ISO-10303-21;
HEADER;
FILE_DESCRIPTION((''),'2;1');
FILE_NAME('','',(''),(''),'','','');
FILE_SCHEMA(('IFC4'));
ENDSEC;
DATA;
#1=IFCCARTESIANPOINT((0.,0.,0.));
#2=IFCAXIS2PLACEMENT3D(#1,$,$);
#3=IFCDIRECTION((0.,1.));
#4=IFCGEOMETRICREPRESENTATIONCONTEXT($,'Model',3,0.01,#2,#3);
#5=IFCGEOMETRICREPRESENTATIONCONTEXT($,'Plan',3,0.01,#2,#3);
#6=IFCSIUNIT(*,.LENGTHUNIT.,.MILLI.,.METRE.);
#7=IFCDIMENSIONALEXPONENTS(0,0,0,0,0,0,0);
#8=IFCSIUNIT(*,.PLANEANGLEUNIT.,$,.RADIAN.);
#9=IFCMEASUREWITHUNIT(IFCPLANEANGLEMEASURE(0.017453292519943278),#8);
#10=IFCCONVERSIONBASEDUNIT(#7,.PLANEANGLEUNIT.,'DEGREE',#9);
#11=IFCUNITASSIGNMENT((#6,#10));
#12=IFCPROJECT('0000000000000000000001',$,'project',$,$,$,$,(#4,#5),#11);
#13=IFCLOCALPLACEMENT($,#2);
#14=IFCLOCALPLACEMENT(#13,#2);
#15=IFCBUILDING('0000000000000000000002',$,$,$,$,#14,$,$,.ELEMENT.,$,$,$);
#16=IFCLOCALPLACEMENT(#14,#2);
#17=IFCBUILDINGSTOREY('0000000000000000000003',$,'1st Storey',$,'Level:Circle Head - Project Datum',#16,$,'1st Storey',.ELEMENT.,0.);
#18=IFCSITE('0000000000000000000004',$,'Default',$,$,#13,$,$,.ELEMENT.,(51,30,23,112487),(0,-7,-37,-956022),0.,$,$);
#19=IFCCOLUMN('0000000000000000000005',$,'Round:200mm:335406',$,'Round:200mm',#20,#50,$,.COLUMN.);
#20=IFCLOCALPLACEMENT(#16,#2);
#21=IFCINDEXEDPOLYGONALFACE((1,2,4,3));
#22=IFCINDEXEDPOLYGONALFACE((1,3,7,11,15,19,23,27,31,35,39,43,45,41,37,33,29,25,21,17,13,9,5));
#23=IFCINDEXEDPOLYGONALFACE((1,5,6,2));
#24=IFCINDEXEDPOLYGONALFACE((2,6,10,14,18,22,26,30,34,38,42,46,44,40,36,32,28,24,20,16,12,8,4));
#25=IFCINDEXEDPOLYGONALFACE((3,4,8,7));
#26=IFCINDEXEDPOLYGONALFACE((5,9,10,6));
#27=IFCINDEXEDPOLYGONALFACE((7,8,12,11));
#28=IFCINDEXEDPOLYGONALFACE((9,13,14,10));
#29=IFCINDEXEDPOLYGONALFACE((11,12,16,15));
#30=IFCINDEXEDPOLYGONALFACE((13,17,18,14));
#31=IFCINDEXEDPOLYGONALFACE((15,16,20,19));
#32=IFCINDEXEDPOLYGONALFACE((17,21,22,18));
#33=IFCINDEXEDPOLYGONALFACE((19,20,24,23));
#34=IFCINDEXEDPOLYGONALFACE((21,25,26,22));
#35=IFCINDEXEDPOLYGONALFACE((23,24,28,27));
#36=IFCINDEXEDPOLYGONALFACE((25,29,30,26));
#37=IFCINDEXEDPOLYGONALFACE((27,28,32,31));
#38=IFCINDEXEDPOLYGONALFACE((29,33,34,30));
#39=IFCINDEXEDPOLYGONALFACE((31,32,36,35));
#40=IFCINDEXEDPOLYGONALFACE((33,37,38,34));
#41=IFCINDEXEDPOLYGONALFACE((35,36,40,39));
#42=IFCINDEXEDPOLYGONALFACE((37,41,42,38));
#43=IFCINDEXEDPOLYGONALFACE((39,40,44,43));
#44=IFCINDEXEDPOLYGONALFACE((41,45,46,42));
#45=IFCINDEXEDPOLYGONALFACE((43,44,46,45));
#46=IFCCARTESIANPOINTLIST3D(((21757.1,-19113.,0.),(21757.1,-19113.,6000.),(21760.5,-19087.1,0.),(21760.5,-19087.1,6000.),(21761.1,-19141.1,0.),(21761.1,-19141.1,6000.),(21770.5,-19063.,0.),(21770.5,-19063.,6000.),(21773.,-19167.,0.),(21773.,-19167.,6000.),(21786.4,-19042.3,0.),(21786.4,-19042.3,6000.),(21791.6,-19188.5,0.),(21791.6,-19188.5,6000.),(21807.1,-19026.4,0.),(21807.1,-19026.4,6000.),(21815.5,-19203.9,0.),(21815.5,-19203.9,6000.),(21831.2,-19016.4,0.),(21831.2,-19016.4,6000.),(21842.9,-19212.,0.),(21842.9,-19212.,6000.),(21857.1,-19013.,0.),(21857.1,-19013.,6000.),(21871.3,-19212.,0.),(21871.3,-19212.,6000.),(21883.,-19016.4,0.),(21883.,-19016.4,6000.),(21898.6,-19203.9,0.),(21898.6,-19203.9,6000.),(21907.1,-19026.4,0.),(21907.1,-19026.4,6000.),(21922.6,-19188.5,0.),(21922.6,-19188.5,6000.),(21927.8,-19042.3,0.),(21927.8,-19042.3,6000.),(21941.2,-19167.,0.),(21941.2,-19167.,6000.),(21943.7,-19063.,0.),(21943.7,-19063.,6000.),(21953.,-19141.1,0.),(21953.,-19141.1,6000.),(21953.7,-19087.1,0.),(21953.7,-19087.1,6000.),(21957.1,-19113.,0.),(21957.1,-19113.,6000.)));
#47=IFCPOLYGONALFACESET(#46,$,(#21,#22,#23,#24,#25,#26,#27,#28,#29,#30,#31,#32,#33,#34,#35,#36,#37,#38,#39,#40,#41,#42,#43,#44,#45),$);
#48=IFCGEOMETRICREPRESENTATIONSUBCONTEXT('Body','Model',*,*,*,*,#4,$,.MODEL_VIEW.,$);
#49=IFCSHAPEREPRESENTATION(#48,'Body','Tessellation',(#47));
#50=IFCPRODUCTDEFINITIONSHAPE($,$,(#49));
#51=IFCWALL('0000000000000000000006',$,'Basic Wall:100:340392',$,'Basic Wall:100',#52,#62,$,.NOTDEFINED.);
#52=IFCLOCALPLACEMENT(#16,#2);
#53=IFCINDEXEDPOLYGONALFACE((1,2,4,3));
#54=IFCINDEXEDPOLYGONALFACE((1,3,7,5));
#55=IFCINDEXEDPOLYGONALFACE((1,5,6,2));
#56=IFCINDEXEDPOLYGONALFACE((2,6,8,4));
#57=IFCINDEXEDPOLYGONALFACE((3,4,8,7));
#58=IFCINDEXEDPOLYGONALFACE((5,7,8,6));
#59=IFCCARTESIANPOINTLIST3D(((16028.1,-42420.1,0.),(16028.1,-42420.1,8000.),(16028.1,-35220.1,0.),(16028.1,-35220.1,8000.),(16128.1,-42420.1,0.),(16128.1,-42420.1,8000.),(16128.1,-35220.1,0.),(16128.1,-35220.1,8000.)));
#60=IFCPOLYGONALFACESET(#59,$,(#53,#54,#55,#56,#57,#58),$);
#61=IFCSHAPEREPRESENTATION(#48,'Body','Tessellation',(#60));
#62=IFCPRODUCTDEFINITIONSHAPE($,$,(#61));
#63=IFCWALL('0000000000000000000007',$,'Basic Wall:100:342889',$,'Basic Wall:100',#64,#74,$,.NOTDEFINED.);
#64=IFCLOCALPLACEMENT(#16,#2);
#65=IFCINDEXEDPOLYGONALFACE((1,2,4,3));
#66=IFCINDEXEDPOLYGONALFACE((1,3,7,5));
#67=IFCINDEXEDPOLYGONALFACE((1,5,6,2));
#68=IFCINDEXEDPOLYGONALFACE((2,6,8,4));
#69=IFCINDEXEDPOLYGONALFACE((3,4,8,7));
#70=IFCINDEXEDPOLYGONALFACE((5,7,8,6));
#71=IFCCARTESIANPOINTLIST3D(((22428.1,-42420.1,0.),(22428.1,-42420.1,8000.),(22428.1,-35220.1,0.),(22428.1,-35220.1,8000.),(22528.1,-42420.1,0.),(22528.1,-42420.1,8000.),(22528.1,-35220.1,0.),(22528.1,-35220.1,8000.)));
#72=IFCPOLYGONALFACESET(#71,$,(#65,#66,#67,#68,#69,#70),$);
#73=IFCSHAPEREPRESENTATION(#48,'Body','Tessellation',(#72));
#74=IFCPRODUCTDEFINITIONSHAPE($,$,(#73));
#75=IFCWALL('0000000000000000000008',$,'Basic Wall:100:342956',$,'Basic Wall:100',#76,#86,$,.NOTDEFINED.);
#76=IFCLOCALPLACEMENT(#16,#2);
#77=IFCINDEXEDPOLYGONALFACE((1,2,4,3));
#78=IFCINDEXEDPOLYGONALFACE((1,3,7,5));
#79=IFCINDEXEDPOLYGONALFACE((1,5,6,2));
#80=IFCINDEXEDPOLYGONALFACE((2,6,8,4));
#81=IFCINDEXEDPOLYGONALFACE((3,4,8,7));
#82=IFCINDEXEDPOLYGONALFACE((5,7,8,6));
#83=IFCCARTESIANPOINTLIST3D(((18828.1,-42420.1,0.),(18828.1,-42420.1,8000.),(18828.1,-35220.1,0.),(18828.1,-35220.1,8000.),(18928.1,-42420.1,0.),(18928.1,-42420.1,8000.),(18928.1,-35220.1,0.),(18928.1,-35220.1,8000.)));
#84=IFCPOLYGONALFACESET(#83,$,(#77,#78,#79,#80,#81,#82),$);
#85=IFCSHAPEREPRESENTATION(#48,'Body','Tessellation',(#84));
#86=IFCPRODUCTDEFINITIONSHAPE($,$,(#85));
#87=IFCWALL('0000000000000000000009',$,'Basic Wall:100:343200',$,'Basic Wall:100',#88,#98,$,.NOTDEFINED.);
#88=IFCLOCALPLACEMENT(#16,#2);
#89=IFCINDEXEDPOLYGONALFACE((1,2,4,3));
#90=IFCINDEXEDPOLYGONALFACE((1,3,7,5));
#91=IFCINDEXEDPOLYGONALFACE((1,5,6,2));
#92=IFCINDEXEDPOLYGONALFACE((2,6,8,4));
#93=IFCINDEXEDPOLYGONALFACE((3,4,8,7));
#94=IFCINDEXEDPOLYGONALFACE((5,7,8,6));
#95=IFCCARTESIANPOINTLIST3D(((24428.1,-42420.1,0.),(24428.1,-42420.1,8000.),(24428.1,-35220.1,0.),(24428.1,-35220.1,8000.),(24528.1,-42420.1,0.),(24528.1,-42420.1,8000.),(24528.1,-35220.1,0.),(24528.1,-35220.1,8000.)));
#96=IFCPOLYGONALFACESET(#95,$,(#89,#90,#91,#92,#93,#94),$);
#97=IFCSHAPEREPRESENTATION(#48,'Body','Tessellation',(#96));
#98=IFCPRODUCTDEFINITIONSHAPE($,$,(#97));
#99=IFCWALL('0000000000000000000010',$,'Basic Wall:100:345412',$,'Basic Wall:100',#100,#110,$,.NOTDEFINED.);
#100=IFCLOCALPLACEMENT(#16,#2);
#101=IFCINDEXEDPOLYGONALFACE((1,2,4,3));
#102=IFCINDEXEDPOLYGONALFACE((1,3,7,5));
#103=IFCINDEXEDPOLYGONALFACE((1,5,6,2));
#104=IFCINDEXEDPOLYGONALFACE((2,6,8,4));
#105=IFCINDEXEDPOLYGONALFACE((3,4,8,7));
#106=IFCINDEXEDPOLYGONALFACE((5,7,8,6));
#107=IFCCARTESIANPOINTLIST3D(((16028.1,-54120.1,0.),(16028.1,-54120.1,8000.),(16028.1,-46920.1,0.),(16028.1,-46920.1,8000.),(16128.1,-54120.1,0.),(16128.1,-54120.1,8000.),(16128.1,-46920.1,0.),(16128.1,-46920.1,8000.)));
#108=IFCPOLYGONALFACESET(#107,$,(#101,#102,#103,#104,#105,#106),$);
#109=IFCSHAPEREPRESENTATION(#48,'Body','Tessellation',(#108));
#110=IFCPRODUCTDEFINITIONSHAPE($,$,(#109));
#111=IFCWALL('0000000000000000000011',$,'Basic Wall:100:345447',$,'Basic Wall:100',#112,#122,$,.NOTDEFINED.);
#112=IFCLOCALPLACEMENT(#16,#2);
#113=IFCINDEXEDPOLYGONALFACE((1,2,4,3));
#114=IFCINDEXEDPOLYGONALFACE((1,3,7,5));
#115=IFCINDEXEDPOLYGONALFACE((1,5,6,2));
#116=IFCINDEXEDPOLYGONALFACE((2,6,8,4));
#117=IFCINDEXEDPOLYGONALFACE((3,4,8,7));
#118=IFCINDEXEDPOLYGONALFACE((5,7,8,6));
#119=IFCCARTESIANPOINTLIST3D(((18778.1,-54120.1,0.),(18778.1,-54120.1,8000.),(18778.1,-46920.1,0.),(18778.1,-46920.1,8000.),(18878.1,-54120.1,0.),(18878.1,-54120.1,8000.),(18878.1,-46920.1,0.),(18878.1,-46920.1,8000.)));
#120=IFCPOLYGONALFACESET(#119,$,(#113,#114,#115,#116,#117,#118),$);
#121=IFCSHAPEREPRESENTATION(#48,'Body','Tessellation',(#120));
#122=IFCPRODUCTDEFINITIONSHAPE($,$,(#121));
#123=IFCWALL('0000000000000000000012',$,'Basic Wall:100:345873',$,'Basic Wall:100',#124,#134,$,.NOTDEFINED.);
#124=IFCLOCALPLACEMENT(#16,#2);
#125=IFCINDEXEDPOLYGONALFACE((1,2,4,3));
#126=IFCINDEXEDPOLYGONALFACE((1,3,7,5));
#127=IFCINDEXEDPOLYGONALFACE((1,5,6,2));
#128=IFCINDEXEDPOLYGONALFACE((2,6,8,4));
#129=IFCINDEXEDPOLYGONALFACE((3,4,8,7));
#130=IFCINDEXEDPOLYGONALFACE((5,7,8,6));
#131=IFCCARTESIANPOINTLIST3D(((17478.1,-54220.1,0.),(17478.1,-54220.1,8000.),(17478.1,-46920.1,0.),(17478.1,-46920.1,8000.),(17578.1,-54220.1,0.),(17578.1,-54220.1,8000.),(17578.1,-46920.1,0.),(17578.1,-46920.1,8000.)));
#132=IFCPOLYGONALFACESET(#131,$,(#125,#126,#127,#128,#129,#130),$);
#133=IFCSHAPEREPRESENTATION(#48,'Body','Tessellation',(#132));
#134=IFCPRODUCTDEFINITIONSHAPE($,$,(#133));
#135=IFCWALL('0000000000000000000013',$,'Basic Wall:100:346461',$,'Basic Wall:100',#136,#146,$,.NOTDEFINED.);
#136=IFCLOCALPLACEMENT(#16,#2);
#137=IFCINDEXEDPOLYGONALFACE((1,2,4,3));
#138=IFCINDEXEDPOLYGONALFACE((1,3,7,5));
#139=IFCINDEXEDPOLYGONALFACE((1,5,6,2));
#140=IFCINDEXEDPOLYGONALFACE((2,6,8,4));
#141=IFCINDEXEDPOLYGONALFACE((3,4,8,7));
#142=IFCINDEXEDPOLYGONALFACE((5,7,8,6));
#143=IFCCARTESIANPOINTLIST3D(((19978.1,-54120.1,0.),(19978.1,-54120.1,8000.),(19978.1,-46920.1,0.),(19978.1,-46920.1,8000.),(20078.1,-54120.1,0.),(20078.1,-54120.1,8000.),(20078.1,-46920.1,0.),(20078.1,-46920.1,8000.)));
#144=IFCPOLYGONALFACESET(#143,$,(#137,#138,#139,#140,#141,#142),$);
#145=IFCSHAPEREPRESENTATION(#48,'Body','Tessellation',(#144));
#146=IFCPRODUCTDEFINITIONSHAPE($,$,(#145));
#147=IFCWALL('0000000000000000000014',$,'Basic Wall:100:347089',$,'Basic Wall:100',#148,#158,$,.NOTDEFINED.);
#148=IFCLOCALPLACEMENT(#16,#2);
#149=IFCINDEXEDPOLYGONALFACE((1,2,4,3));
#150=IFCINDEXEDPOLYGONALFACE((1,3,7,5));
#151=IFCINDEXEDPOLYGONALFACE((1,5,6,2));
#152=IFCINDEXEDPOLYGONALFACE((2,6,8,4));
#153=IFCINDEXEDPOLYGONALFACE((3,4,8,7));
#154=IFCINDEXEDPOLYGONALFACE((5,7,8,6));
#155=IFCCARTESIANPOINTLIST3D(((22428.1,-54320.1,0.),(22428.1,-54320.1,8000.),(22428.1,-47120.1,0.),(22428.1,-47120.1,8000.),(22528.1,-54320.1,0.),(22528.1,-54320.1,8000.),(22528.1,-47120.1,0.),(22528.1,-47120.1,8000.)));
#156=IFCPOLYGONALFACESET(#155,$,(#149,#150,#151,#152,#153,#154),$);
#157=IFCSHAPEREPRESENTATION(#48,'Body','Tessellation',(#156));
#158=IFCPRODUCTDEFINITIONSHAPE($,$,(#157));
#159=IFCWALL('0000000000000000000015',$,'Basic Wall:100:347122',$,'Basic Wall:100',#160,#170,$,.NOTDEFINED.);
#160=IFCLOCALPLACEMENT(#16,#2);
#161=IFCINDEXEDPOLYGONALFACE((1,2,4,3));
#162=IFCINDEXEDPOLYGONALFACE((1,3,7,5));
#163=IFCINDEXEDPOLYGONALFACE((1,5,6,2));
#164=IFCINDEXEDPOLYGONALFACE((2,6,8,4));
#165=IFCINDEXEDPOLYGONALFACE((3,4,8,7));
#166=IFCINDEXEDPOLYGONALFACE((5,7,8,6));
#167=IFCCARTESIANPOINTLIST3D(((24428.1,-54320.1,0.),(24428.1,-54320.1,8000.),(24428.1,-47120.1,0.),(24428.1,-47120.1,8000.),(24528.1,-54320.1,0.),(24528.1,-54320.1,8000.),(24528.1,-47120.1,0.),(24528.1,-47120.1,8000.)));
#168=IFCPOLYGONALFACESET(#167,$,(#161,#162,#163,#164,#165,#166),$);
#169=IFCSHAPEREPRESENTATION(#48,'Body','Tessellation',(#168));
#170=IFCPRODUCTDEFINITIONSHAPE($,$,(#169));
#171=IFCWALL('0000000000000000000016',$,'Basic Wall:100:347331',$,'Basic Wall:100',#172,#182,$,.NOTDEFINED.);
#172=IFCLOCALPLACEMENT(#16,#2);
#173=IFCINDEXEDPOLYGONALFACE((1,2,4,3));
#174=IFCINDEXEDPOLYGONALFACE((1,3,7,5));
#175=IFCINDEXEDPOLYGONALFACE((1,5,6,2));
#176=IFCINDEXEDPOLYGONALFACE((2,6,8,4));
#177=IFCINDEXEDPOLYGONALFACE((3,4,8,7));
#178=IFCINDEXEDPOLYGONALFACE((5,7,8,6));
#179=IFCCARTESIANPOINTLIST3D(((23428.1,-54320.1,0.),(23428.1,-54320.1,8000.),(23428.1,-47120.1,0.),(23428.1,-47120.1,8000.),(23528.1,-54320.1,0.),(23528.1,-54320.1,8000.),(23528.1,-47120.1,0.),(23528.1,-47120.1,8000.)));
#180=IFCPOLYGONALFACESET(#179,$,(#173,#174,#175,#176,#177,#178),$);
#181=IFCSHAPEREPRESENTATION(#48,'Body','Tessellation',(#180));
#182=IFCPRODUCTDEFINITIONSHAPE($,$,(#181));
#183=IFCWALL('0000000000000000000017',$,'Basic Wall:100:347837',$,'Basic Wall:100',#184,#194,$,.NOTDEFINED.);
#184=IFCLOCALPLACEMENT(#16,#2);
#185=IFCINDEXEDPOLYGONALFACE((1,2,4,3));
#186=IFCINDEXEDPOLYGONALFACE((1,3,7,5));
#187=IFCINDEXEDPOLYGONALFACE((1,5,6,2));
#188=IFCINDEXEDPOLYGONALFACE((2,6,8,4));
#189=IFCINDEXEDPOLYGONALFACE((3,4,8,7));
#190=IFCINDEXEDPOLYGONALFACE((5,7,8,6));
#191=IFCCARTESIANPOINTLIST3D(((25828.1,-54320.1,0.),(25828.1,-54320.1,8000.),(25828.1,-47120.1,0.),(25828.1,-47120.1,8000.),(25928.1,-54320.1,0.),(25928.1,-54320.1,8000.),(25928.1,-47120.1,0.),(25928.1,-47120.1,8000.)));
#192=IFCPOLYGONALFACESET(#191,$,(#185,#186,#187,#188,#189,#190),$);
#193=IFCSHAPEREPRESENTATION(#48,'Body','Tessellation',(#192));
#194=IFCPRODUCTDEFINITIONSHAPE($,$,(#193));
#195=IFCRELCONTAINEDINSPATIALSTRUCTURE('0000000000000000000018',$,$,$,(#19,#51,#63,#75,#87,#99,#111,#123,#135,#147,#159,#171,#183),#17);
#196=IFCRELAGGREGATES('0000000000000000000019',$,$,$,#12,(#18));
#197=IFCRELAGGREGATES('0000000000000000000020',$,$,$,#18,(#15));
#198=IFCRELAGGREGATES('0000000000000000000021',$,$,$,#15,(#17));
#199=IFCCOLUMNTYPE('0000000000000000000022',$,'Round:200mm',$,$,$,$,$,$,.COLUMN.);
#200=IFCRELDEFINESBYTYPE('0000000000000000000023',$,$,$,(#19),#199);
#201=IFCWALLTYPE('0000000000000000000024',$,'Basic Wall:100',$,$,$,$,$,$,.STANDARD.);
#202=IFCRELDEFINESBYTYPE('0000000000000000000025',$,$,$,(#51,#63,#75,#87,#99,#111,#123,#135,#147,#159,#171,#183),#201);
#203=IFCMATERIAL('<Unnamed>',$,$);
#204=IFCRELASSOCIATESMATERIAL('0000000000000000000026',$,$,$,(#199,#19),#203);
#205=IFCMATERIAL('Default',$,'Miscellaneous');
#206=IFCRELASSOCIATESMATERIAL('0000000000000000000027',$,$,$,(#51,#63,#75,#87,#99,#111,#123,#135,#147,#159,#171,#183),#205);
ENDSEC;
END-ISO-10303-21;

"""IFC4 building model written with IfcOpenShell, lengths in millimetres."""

from ifc_helpers import new_model, entity, si_unit, converted_unit, direction, frame, origin, place, context, subcontext, project, spatial, arc, indexed_curve, outline, extrude, source, transform, mapped, material, type_object, type_shapes, element, save


model = new_model("IFC4")

# Units and contexts
model_context = context("Model", 3, precision=0.01, world=origin(), true_north=direction((0.0, 1.0)))
plan_context = context("Plan", 3, precision=0.01, world=origin(), true_north=direction((0.0, 1.0)))
body_context = subcontext(model_context, "Body", "Model", "MODEL_VIEW")
ifc_project = project(units=[si_unit("LENGTHUNIT", "METRE", prefix="MILLI"), converted_unit("PLANEANGLEUNIT", "DEGREE", entity("IfcPlaneAngleMeasure", 0.017453292519943278), si_unit("PLANEANGLEUNIT", "RADIAN"), dimensions=[0, 0, 0, 0, 0, 0, 0])], contexts=[model_context, plan_context])

# Site, building, storey
site_placement = place(None, origin())
site = spatial("IfcSite", under=ifc_project, at=site_placement, Name="Default", CompositionType="ELEMENT", RefLatitude=(51, 30, 23, 112487), RefLongitude=(0, -7, -37, -956022), RefElevation=0.0)
building_placement = place(site_placement, origin())
building = spatial("IfcBuilding", under=site, at=building_placement, CompositionType="ELEMENT")
storey_placement = place(building_placement, origin())
storey = spatial("IfcBuildingStorey", under=building, at=storey_placement, Name="1st Storey", ObjectType="Level:Circle Head - Project Datum", LongName="1st Storey", CompositionType="ELEMENT", Elevation=0.0)

# Column
ifc_material_1 = material(Name="<Unnamed>")
column_type_1 = type_object("IfcColumnType", Name="Round:200mm", PredefinedType="COLUMN", material=ifc_material_1)
shared_shape_1 = source(origin(), body_context, "Body", "SweptSolid", [
    extrude(outline(indexed_curve([(100.0, -33.3), (70.7, 37.4), (0.0, 66.7), (-70.7, 37.4), (-100.0, -33.3), (0.0, -133.3)], segments=[arc(1, 2, 3), arc(3, 4, 5), arc(5, 6, 1)], self_intersect=False)), frame((0.0, 33.3, 0.0)), (0.0, 0.0, 1.0), 6000.0),
])
type_shapes(column_type_1, [shared_shape_1])
column_1_placement = place(storey_placement, frame((21857.1, -19113.0, 0.0)))
element("IfcColumn", 1, at=column_1_placement, inside=storey, type_object=column_type_1, material=ifc_material_1, Name="Round:200mm:335406", ObjectType="Round:200mm", PredefinedType="COLUMN", context=body_context, shape_type="MappedRepresentation", body=[
    mapped(shared_shape_1, transform((0.0, 0.0, 0.0), scale=1.0)),
])

# Walls
ifc_material_2 = material(Name="Default", Category="Miscellaneous")
wall_type = type_object("IfcWallType", Name="Basic Wall:100", PredefinedType="STANDARD")
wall_1_placement = place(storey_placement, frame((16078.1, -42420.1, 0.0), z_axis=(0.0, 0.0, 1.0), x_axis=(0.0, 1.0, 0.0)))
element("IfcWall", 2, at=wall_1_placement, inside=storey, type_object=wall_type, material=ifc_material_2, Name="Basic Wall:100:340392", ObjectType="Basic Wall:100", PredefinedType="NOTDEFINED", context=body_context, shape_type="SweptSolid", body=[
    extrude(outline(indexed_curve([(7200.0, 50.0), (0.0, 50.0), (0.0, -50.0), (7200.0, -50.0), (7200.0, 50.0)], self_intersect=False)), origin(), (0.0, 0.0, 1.0), 8000.0),
])
wall_2_placement = place(storey_placement, frame((22478.1, -42420.1, 0.0), z_axis=(0.0, 0.0, 1.0), x_axis=(0.0, 1.0, 0.0)))
element("IfcWall", 3, at=wall_2_placement, inside=storey, type_object=wall_type, material=ifc_material_2, Name="Basic Wall:100:342889", ObjectType="Basic Wall:100", PredefinedType="NOTDEFINED", context=body_context, shape_type="SweptSolid", body=[
    extrude(outline(indexed_curve([(7200.0, 50.0), (0.0, 50.0), (0.0, -50.0), (7200.0, -50.0), (7200.0, 50.0)], self_intersect=False)), origin(), (0.0, 0.0, 1.0), 8000.0),
])
wall_3_placement = place(storey_placement, frame((18878.1, -42420.1, 0.0), z_axis=(0.0, 0.0, 1.0), x_axis=(0.0, 1.0, 0.0)))
element("IfcWall", 4, at=wall_3_placement, inside=storey, type_object=wall_type, material=ifc_material_2, Name="Basic Wall:100:342956", ObjectType="Basic Wall:100", PredefinedType="NOTDEFINED", context=body_context, shape_type="SweptSolid", body=[
    extrude(outline(indexed_curve([(7200.0, 50.0), (0.0, 50.0), (0.0, -50.0), (7200.0, -50.0), (7200.0, 50.0)], self_intersect=False)), origin(), (0.0, 0.0, 1.0), 8000.0),
])
wall_4_placement = place(storey_placement, frame((24478.1, -42420.1, 0.0), z_axis=(0.0, 0.0, 1.0), x_axis=(0.0, 1.0, 0.0)))
element("IfcWall", 5, at=wall_4_placement, inside=storey, type_object=wall_type, material=ifc_material_2, Name="Basic Wall:100:343200", ObjectType="Basic Wall:100", PredefinedType="NOTDEFINED", context=body_context, shape_type="SweptSolid", body=[
    extrude(outline(indexed_curve([(7200.0, 50.0), (0.0, 50.0), (0.0, -50.0), (7200.0, -50.0), (7200.0, 50.0)], self_intersect=False)), origin(), (0.0, 0.0, 1.0), 8000.0),
])
for number, where, z_axis, x_axis, name in (
    (6, (16078.1, -54120.1, 0.0), (0.0, 0.0, 1.0), (0.0, 1.0, 0.0), "Basic Wall:100:345412"),
    (7, (18828.1, -54120.1, 0.0), (0.0, 0.0, 1.0), (0.0, 1.0, 0.0), "Basic Wall:100:345447"),
):
    element("IfcWall", number, at=place(storey_placement, frame(where, z_axis=z_axis, x_axis=x_axis)), inside=storey, type_object=wall_type, material=ifc_material_2, Name=name, ObjectType="Basic Wall:100", PredefinedType="NOTDEFINED", context=body_context, shape_type="SweptSolid", body=[
        extrude(outline(indexed_curve([(7200.0, 50.0), (0.0, 50.0), (0.0, -50.0), (7200.0, -50.0), (7200.0, 50.0)], self_intersect=False)), origin(), (0.0, 0.0, 1.0), 8000.0),
    ])
wall_5_placement = place(storey_placement, frame((17528.1, -46920.1, 0.0), z_axis=(0.0, 0.0, 1.0), x_axis=(0.0, -1.0, 0.0)))
element("IfcWall", 8, at=wall_5_placement, inside=storey, type_object=wall_type, material=ifc_material_2, Name="Basic Wall:100:345873", ObjectType="Basic Wall:100", PredefinedType="NOTDEFINED", context=body_context, shape_type="SweptSolid", body=[
    extrude(outline(indexed_curve([(7300.0, 50.0), (0.0, 50.0), (0.0, -50.0), (7300.0, -50.0), (7300.0, 50.0)], self_intersect=False)), origin(), (0.0, 0.0, 1.0), 8000.0),
])
wall_6_placement = place(storey_placement, frame((20028.1, -54120.1, 0.0), z_axis=(0.0, 0.0, 1.0), x_axis=(0.0, 1.0, 0.0)))
element("IfcWall", 9, at=wall_6_placement, inside=storey, type_object=wall_type, material=ifc_material_2, Name="Basic Wall:100:346461", ObjectType="Basic Wall:100", PredefinedType="NOTDEFINED", context=body_context, shape_type="SweptSolid", body=[
    extrude(outline(indexed_curve([(7200.0, 50.0), (0.0, 50.0), (0.0, -50.0), (7200.0, -50.0), (7200.0, 50.0)], self_intersect=False)), origin(), (0.0, 0.0, 1.0), 8000.0),
])
for number, where, z_axis, x_axis, name in (
    (10, (22478.1, -54320.1, 0.0), (0.0, 0.0, 1.0), (0.0, 1.0, 0.0), "Basic Wall:100:347089"),
    (11, (24478.1, -54320.1, 0.0), (0.0, 0.0, 1.0), (0.0, 1.0, 0.0), "Basic Wall:100:347122"),
):
    element("IfcWall", number, at=place(storey_placement, frame(where, z_axis=z_axis, x_axis=x_axis)), inside=storey, type_object=wall_type, material=ifc_material_2, Name=name, ObjectType="Basic Wall:100", PredefinedType="NOTDEFINED", context=body_context, shape_type="SweptSolid", body=[
        extrude(outline(indexed_curve([(7200.0, 50.0), (0.0, 50.0), (0.0, -50.0), (7200.0, -50.0), (7200.0, 50.0)], self_intersect=False)), origin(), (0.0, 0.0, 1.0), 8000.0),
    ])
for number, where, z_axis, x_axis, name in (
    (12, (23478.1, -47120.1, 0.0), (0.0, 0.0, 1.0), (0.0, -1.0, 0.0), "Basic Wall:100:347331"),
    (13, (25878.1, -47120.1, 0.0), (0.0, 0.0, 1.0), (0.0, -1.0, 0.0), "Basic Wall:100:347837"),
):
    element("IfcWall", number, at=place(storey_placement, frame(where, z_axis=z_axis, x_axis=x_axis)), inside=storey, type_object=wall_type, material=ifc_material_2, Name=name, ObjectType="Basic Wall:100", PredefinedType="NOTDEFINED", context=body_context, shape_type="SweptSolid", body=[
        extrude(outline(indexed_curve([(7200.0, 50.0), (0.0, 50.0), (0.0, -50.0), (7200.0, -50.0), (7200.0, 50.0)], self_intersect=False)), origin(), (0.0, 0.0, 1.0), 8000.0),
    ])

save(model, "model.ifc")
